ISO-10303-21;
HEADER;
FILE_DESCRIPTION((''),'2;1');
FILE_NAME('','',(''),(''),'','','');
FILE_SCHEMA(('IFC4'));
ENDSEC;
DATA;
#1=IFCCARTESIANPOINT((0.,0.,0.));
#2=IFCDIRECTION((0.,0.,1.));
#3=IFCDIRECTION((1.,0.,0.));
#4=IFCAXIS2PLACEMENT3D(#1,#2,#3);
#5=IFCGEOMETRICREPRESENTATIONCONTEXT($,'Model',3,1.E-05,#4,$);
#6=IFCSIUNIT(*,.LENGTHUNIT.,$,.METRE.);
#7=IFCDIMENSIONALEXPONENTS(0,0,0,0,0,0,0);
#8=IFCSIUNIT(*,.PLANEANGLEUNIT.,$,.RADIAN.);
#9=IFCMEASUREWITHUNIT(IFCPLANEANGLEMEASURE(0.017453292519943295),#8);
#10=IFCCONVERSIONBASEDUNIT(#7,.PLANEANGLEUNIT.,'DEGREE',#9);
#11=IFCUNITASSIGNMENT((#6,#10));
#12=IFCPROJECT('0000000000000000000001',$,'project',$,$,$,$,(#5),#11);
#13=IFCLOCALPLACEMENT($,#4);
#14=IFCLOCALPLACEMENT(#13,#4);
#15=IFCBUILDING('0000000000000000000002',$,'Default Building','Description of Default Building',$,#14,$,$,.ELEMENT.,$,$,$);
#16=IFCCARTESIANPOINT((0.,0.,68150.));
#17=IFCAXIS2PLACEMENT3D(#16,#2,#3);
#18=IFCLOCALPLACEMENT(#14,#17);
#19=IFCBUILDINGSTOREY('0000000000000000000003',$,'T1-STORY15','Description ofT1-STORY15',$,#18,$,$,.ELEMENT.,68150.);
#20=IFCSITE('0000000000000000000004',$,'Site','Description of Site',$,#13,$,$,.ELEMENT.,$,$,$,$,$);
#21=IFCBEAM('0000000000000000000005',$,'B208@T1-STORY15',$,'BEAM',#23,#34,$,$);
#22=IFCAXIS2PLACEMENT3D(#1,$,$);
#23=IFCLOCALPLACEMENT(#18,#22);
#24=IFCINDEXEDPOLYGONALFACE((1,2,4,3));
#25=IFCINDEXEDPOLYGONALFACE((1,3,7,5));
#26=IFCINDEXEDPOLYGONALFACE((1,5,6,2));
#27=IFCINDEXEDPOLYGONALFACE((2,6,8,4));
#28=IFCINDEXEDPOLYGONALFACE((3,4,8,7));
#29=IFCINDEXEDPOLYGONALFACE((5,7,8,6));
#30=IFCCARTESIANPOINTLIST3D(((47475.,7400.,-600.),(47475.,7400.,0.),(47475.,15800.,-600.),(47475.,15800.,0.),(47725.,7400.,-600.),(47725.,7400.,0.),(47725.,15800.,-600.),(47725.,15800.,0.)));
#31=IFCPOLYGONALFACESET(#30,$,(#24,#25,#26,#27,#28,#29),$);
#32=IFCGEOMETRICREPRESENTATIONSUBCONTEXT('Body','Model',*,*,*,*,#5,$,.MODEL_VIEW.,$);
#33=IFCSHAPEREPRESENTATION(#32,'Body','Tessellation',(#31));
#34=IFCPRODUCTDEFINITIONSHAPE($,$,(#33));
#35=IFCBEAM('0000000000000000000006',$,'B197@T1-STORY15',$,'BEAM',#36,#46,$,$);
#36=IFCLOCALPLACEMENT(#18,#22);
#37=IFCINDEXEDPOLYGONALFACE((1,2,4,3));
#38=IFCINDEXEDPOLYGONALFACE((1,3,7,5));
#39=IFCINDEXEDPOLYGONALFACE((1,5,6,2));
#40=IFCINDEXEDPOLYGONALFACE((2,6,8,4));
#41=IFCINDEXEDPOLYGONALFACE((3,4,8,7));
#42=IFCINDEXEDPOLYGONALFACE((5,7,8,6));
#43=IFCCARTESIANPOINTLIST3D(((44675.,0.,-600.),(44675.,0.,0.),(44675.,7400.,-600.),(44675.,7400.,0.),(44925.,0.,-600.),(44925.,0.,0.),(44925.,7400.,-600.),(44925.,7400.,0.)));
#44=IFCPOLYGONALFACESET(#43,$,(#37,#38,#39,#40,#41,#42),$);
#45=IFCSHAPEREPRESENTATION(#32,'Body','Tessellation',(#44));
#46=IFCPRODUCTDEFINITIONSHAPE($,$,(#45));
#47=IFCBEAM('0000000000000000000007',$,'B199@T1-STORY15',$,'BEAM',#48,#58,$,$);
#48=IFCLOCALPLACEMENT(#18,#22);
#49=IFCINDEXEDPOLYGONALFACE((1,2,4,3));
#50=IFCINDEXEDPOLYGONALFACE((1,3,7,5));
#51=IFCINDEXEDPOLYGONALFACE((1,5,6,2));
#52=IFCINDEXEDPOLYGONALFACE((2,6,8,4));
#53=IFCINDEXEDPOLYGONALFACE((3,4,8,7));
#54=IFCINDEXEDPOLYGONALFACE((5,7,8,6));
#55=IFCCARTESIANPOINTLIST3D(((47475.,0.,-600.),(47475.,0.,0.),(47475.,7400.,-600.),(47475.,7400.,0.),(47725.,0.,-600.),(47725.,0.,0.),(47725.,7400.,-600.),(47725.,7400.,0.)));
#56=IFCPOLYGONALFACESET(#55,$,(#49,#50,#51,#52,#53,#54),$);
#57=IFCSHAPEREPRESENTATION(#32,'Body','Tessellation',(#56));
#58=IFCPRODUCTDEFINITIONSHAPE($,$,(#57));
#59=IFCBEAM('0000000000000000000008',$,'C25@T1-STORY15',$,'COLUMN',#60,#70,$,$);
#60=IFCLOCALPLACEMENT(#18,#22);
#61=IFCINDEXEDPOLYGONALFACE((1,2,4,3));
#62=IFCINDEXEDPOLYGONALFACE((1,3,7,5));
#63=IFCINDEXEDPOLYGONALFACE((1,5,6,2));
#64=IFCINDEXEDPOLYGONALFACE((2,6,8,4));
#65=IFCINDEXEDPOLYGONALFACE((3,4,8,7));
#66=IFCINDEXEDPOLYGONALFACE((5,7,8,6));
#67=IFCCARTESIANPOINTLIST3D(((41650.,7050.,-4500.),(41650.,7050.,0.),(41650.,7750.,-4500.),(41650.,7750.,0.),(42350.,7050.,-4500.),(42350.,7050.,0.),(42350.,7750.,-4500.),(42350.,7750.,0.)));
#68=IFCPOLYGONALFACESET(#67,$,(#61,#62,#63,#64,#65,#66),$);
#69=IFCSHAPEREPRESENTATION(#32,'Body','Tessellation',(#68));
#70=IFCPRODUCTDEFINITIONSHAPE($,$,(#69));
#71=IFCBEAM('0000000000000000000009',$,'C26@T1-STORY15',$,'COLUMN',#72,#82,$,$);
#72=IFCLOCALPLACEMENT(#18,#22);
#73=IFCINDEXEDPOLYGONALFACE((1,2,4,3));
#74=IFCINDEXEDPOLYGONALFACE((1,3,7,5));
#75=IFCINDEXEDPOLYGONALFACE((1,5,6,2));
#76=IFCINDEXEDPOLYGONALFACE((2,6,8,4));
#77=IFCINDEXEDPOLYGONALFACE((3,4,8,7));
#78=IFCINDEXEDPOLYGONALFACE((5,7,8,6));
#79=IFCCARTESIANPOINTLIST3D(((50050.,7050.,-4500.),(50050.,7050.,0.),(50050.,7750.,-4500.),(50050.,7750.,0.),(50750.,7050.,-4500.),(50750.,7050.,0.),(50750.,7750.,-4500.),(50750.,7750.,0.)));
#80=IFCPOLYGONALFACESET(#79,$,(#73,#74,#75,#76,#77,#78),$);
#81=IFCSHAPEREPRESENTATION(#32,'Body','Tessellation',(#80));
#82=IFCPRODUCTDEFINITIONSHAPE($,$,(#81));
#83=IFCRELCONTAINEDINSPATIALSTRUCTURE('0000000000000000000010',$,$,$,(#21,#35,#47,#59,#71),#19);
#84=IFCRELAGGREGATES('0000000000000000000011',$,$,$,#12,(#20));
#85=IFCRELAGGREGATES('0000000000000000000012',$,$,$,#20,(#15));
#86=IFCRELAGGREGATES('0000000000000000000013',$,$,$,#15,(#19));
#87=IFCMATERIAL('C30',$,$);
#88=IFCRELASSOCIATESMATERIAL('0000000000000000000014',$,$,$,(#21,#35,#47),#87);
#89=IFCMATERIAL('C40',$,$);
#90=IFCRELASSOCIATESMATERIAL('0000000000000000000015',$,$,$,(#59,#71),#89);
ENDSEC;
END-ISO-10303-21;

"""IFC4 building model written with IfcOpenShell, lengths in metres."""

from ifc_helpers import new_model, entity, si_unit, converted_unit, frame, origin_with_axes, place, context, subcontext, project, spatial, rectangle, extrude, material, element, save


model = new_model("IFC4")

# Units and contexts
model_context = context("Model", 3, precision=1e-05, world=origin_with_axes())
body_context = subcontext(model_context, "Body", "Model", "MODEL_VIEW")
ifc_project = project(units=[si_unit("LENGTHUNIT", "METRE"), converted_unit("PLANEANGLEUNIT", "DEGREE", entity("IfcPlaneAngleMeasure", 0.017453292519943295), si_unit("PLANEANGLEUNIT", "RADIAN"), dimensions=[0, 0, 0, 0, 0, 0, 0])], contexts=[model_context])

# Site, building, storey
site_placement = place(None, origin_with_axes())
site = spatial("IfcSite", under=ifc_project, at=site_placement, Name="Site", Description="Description of Site", CompositionType="ELEMENT")
building_placement = place(site_placement, origin_with_axes())
building = spatial("IfcBuilding", under=site, at=building_placement, Name="Default Building", Description="Description of Default Building", CompositionType="ELEMENT")
storey_placement = place(building_placement, frame((0.0, 0.0, 68150.0), z_axis=(0.0, 0.0, 1.0), x_axis=(1.0, 0.0, 0.0)))
storey = spatial("IfcBuildingStorey", under=building, at=storey_placement, Name="T1-STORY15", Description="Description ofT1-STORY15", CompositionType="ELEMENT", Elevation=68150.0)

# Beams
ifc_material_1 = material(Name="C30")
for number, where, z_axis, x_axis, name in (
    (1, (47600.0, 7400.0, -300.0), (0.0, 1.0, 0.0), (-1.0, 0.0, 0.0), "B208@T1-STORY15"),
):
    element("IfcBeam", number, at=place(storey_placement, frame(where, z_axis=z_axis, x_axis=x_axis)), inside=storey, material=ifc_material_1, Name=name, ObjectType="BEAM", context=body_context, shape_type="SweptSolid", body=[
        extrude(rectangle(XDim=250.0, YDim=600.0), origin_with_axes(), (0.0, 0.0, 1.0), 8400.0),
    ])
for number, where, z_axis, x_axis, name in (
    (2, (44800.0, 0.0, -300.0), (0.0, 1.0, 0.0), (-1.0, 0.0, 0.0), "B197@T1-STORY15"),
    (3, (47600.0, 0.0, -300.0), (0.0, 1.0, 0.0), (-1.0, 0.0, 0.0), "B199@T1-STORY15"),
):
    element("IfcBeam", number, at=place(storey_placement, frame(where, z_axis=z_axis, x_axis=x_axis)), inside=storey, material=ifc_material_1, Name=name, ObjectType="BEAM", context=body_context, shape_type="SweptSolid", body=[
        extrude(rectangle(XDim=250.0, YDim=600.0), origin_with_axes(), (0.0, 0.0, 1.0), 7400.0),
    ])
ifc_material_2 = material(Name="C40")
for number, where, z_axis, x_axis, name in (
    (4, (42000.0, 7400.0, -4500.0), (0.0, 0.0, 1.0), (-1.0, 0.0, 0.0), "C25@T1-STORY15"),
    (5, (50400.0, 7400.0, -4500.0), (0.0, 0.0, 1.0), (-1.0, 0.0, 0.0), "C26@T1-STORY15"),
):
    element("IfcBeam", number, at=place(storey_placement, frame(where, z_axis=z_axis, x_axis=x_axis)), inside=storey, material=ifc_material_2, Name=name, ObjectType="COLUMN", context=body_context, shape_type="SweptSolid", body=[
        extrude(rectangle(XDim=700.0, YDim=700.0), origin_with_axes(), (0.0, 0.0, 1.0), 4500.0),
    ])

save(model, "model.ifc")
